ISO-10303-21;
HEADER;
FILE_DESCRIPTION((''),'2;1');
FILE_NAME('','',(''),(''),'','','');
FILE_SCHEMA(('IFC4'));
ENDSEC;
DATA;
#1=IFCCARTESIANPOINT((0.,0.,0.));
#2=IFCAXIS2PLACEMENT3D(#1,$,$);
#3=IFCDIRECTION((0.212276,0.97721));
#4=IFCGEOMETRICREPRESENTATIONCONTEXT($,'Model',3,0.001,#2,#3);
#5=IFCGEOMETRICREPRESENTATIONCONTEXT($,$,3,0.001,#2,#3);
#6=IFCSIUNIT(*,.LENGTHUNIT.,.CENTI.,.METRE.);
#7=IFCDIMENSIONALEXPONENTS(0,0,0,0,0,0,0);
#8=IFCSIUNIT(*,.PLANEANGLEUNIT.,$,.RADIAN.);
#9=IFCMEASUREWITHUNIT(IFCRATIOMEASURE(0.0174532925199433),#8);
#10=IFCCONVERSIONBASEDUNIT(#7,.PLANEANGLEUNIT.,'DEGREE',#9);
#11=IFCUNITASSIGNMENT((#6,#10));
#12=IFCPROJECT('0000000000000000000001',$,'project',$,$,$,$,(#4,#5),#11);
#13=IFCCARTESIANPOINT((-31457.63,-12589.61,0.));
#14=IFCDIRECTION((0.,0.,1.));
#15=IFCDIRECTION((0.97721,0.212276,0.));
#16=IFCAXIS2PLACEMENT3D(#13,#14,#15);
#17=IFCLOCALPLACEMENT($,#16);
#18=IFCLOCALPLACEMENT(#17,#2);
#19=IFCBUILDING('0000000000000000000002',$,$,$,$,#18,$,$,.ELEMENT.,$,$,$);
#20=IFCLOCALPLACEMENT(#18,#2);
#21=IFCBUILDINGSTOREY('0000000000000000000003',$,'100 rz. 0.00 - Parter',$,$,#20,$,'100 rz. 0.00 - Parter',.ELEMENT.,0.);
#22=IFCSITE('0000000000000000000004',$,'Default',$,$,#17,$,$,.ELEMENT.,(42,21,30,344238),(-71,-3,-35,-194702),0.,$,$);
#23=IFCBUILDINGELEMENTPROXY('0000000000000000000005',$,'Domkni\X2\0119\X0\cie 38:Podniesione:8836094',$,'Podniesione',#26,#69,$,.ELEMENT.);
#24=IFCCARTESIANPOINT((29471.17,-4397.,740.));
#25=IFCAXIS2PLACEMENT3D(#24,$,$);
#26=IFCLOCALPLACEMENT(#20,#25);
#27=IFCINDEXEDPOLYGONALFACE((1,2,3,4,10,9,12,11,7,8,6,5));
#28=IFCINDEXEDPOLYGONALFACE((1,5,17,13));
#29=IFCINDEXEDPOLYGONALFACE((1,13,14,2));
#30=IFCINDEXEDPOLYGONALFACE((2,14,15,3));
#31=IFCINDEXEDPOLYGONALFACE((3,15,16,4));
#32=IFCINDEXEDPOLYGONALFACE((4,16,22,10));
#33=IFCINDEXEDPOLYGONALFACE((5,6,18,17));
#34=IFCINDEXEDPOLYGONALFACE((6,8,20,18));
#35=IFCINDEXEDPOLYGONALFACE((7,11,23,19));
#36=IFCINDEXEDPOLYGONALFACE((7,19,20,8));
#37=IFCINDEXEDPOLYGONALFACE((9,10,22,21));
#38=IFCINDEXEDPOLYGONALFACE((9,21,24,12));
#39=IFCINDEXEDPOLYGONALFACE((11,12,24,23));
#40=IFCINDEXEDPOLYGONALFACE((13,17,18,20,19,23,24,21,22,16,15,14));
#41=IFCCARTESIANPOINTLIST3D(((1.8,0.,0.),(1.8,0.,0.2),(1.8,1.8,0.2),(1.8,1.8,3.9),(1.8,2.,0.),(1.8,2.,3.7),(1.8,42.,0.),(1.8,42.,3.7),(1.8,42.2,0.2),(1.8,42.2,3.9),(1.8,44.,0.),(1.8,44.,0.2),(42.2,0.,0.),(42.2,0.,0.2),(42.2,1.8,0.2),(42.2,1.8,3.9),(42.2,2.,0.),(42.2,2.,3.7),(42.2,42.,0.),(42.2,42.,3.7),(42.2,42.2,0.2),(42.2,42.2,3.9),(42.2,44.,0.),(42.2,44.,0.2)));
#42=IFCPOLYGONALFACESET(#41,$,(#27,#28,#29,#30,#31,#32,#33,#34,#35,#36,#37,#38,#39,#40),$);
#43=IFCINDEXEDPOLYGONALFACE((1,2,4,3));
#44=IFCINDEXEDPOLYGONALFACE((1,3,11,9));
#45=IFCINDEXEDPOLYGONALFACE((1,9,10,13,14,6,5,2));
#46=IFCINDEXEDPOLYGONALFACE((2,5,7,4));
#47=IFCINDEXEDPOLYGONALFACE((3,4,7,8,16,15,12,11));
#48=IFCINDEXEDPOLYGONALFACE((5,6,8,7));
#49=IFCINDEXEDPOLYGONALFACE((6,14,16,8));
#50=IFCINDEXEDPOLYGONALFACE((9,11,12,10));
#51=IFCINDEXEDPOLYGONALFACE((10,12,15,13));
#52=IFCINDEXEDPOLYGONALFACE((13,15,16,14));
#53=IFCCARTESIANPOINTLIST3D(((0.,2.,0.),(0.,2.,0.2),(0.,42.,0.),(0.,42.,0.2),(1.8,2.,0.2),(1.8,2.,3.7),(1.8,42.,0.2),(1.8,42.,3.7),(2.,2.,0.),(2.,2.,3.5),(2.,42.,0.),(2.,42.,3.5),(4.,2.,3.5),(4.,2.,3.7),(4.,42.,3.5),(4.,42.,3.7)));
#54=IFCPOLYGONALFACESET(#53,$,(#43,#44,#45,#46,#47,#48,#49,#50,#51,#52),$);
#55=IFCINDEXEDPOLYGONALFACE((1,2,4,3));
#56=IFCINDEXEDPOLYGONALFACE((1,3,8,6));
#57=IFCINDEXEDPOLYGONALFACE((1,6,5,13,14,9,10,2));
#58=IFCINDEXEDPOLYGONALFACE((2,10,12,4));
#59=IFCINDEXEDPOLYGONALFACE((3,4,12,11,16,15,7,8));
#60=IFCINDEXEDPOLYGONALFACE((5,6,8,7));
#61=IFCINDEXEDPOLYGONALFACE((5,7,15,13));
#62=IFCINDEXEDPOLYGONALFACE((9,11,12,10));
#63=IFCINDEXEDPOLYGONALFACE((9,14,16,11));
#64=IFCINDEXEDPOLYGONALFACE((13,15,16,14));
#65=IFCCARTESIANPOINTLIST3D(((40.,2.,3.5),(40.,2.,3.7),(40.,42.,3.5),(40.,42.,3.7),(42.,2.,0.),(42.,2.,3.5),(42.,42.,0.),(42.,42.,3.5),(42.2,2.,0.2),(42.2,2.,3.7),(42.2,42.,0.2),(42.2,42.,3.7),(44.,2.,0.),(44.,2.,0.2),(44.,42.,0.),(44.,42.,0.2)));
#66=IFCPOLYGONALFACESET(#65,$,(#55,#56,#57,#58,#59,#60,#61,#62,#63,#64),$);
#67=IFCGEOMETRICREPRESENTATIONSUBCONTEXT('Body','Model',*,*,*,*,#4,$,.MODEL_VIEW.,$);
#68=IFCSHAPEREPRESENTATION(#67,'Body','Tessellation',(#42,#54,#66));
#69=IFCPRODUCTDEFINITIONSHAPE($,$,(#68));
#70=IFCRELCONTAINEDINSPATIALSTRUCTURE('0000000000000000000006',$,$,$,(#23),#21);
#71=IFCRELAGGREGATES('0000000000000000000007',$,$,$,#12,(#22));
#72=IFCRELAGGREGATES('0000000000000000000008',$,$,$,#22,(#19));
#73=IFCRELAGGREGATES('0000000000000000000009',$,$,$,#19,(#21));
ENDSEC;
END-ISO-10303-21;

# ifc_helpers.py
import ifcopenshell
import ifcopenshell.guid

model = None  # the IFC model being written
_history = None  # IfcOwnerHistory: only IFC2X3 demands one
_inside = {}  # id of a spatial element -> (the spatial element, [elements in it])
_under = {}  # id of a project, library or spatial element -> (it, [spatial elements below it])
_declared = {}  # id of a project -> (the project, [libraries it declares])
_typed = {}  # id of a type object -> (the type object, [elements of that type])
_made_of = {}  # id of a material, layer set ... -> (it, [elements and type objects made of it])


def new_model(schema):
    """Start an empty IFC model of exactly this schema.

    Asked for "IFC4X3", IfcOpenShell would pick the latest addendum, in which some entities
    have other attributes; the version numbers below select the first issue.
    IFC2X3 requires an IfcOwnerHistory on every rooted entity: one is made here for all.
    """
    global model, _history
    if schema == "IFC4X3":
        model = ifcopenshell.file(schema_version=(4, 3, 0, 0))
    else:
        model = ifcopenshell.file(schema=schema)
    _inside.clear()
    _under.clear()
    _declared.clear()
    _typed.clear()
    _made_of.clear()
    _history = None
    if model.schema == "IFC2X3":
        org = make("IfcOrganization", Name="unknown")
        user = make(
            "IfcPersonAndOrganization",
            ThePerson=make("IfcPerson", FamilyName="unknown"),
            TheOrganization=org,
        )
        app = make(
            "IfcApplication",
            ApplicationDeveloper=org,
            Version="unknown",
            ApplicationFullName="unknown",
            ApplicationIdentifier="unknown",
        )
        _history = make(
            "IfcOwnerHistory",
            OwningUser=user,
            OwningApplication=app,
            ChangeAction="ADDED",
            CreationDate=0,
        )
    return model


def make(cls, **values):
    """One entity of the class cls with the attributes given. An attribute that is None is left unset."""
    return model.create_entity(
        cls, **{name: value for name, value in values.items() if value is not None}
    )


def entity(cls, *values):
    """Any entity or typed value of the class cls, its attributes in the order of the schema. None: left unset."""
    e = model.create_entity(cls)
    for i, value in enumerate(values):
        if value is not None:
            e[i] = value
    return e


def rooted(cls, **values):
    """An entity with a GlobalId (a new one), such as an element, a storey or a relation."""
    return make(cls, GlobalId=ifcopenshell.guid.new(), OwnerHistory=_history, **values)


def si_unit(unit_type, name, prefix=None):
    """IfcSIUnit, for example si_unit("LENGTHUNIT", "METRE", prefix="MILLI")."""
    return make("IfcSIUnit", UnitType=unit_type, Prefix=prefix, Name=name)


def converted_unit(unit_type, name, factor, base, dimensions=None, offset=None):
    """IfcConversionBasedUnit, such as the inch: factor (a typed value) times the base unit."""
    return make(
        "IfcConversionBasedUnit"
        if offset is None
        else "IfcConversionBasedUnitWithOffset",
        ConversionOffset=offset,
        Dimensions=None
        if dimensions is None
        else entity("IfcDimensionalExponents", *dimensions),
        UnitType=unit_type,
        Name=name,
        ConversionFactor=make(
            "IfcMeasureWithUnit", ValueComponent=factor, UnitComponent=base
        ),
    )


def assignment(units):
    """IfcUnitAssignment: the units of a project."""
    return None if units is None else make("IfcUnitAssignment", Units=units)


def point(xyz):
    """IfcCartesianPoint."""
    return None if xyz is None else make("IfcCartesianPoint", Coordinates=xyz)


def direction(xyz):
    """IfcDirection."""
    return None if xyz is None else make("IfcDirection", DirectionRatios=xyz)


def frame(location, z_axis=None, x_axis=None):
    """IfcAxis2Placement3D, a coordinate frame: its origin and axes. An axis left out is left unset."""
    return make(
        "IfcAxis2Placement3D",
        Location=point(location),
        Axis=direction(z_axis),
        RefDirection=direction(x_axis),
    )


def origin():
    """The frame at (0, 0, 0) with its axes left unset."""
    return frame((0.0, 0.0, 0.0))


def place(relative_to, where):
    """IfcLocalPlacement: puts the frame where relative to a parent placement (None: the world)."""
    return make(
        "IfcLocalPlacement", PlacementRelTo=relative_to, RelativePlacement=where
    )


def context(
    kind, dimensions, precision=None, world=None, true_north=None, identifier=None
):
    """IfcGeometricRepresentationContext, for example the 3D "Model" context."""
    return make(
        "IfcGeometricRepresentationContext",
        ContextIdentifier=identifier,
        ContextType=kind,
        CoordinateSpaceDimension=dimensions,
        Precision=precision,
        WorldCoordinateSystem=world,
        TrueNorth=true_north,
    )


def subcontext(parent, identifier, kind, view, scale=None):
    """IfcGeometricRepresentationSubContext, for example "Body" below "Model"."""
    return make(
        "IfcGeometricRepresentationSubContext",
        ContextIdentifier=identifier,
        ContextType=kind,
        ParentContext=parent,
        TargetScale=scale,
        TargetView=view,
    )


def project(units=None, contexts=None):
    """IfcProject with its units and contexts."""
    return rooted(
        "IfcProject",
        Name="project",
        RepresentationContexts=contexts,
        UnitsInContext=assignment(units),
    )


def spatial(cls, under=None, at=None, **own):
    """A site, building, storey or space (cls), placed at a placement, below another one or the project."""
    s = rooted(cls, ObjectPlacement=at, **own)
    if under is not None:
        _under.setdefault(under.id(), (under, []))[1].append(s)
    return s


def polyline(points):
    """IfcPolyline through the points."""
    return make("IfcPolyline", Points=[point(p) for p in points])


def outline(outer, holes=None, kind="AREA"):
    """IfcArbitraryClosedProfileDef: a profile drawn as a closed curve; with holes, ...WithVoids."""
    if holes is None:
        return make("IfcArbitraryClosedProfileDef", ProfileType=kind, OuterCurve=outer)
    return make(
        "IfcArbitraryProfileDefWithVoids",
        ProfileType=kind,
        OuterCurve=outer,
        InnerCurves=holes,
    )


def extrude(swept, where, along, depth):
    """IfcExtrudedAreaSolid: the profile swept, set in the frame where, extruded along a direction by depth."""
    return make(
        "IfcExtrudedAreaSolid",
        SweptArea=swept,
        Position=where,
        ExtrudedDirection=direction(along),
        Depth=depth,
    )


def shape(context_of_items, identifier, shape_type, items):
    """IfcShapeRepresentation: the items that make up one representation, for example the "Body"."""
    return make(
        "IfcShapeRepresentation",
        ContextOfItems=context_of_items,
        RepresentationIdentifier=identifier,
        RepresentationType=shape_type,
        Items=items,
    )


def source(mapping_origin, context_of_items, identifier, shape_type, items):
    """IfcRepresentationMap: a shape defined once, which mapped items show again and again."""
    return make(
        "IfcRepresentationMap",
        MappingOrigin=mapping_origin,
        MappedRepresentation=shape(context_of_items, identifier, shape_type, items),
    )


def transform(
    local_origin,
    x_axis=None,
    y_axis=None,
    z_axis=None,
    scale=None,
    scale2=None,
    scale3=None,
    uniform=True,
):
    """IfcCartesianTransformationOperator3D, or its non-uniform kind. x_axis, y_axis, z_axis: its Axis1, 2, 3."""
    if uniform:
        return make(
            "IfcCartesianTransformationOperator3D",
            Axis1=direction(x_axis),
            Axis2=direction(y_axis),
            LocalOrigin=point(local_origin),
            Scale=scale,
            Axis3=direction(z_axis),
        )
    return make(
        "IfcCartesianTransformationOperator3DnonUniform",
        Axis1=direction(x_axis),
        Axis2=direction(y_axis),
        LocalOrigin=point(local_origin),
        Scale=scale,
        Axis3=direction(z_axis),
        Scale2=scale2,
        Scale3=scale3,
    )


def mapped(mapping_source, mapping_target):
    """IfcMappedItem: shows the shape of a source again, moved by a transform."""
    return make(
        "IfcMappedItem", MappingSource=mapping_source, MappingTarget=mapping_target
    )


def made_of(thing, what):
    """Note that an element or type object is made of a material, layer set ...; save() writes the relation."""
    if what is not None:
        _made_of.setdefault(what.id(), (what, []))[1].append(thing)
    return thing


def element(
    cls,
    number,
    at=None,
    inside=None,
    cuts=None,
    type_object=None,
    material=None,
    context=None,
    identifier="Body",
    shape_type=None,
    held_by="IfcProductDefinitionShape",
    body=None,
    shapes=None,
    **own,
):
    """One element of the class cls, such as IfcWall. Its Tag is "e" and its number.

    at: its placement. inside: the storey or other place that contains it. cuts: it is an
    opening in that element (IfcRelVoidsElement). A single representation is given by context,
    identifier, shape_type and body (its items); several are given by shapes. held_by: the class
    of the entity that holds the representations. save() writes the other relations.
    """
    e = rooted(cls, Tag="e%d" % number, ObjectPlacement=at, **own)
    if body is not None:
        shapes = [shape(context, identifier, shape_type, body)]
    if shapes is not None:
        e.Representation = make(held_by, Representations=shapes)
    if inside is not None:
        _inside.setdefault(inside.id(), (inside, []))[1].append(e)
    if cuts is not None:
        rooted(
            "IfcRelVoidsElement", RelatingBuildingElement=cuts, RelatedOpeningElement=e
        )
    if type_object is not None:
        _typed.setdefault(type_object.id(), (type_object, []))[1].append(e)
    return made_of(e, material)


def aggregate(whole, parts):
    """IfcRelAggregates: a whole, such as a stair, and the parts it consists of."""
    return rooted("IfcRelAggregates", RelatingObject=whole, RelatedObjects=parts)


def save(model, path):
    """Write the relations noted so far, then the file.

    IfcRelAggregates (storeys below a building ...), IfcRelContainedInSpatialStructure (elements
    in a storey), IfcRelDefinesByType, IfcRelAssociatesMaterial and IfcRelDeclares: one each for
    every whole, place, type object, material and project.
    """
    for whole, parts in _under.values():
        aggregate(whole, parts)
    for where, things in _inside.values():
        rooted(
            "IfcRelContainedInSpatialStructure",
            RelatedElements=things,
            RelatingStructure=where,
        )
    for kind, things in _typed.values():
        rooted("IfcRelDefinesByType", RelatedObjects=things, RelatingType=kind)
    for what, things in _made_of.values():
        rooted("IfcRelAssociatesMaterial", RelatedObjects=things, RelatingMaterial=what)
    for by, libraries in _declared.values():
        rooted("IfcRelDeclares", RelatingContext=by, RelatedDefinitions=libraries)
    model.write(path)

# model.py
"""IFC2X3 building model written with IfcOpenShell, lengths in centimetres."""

from ifc_helpers import new_model, entity, si_unit, converted_unit, direction, frame, origin, place, context, subcontext, project, spatial, polyline, outline, extrude, source, transform, mapped, element, save


model = new_model("IFC2X3")

# Units and contexts
model_context = context("Model", 3, precision=0.001, world=origin(), true_north=direction((0.212276, 0.97721)))
context_of_model = context(None, 3, precision=0.001, world=origin(), true_north=direction((0.212276, 0.97721)))
body_context = subcontext(model_context, "Body", "Model", "MODEL_VIEW")
ifc_project = project(units=[si_unit("LENGTHUNIT", "METRE", prefix="CENTI"), converted_unit("PLANEANGLEUNIT", "DEGREE", entity("IfcRatioMeasure", 0.0174532925199433), si_unit("PLANEANGLEUNIT", "RADIAN"), dimensions=[0, 0, 0, 0, 0, 0, 0])], contexts=[model_context, context_of_model])

# Site, building, storey
site_placement = place(None, frame((-31457.63, -12589.61, 0.0), z_axis=(0.0, 0.0, 1.0), x_axis=(0.97721, 0.212276, 0.0)))
site = spatial("IfcSite", under=ifc_project, at=site_placement, Name="Default", CompositionType="ELEMENT", RefLatitude=(42, 21, 30, 344238), RefLongitude=(-71, -3, -35, -194702), RefElevation=0.0)
building_placement = place(site_placement, origin())
building = spatial("IfcBuilding", under=site, at=building_placement, CompositionType="ELEMENT")
storey_placement = place(building_placement, origin())
storey = spatial("IfcBuildingStorey", under=building, at=storey_placement, Name="100 rz. 0.00 - Parter", LongName="100 rz. 0.00 - Parter", CompositionType="ELEMENT", Elevation=0.0)

# Building element proxy
shared_shape_1 = source(origin(), body_context, "Body", "SweptSolid", [
    extrude(outline(polyline([(-2.37, 20.0), (1.33, 20.0), (1.33, 22.0), (1.13, 22.0), (1.13, 20.2), (-2.57, 20.2), (-2.57, -20.2), (1.13, -20.2), (1.13, -22.0), (1.33, -22.0), (1.33, -20.0), (-2.37, -20.0), (-2.37, 20.0)])), frame((1.8, 22.0, 1.33), z_axis=(1.0, 0.0, 0.0), x_axis=(0.0, 0.0, -1.0)), (0.0, 0.0, 1.0), 40.4),
    extrude(outline(polyline([(-1.65, -0.05), (1.85, -0.05), (1.85, 1.95), (1.65, 1.95), (1.65, 0.15), (-1.85, 0.15), (-1.85, -2.05), (-1.65, -2.05), (-1.65, -0.05)])), frame((1.95, 2.0, 1.85), z_axis=(0.0, 1.0, 0.0), x_axis=(0.0, 0.0, -1.0)), (0.0, 0.0, 1.0), 40.0),
    extrude(outline(polyline([(0.05, 1.65), (2.05, 1.65), (2.05, 1.85), (-0.15, 1.85), (-0.15, -1.65), (-1.95, -1.65), (-1.95, -1.85), (0.05, -1.85), (0.05, 1.65)])), frame((42.05, 2.0, 1.85), z_axis=(0.0, 1.0, 0.0), x_axis=(-1.0, 0.0, 0.0)), (0.0, 0.0, 1.0), 40.0),
])
for number, where, name in (
    (1, (29471.17, -4397.0, 740.0), "Domknięcie 38:Podniesione:8836094"),
):
    element("IfcBuildingElementProxy", number, at=place(storey_placement, frame(where)), inside=storey, Name=name, ObjectType="Podniesione", CompositionType="ELEMENT", context=body_context, shape_type="MappedRepresentation", body=[
        mapped(shared_shape_1, transform((0.0, 0.0, 0.0), scale=1.0)),
    ])

save(model, "model.ifc")
